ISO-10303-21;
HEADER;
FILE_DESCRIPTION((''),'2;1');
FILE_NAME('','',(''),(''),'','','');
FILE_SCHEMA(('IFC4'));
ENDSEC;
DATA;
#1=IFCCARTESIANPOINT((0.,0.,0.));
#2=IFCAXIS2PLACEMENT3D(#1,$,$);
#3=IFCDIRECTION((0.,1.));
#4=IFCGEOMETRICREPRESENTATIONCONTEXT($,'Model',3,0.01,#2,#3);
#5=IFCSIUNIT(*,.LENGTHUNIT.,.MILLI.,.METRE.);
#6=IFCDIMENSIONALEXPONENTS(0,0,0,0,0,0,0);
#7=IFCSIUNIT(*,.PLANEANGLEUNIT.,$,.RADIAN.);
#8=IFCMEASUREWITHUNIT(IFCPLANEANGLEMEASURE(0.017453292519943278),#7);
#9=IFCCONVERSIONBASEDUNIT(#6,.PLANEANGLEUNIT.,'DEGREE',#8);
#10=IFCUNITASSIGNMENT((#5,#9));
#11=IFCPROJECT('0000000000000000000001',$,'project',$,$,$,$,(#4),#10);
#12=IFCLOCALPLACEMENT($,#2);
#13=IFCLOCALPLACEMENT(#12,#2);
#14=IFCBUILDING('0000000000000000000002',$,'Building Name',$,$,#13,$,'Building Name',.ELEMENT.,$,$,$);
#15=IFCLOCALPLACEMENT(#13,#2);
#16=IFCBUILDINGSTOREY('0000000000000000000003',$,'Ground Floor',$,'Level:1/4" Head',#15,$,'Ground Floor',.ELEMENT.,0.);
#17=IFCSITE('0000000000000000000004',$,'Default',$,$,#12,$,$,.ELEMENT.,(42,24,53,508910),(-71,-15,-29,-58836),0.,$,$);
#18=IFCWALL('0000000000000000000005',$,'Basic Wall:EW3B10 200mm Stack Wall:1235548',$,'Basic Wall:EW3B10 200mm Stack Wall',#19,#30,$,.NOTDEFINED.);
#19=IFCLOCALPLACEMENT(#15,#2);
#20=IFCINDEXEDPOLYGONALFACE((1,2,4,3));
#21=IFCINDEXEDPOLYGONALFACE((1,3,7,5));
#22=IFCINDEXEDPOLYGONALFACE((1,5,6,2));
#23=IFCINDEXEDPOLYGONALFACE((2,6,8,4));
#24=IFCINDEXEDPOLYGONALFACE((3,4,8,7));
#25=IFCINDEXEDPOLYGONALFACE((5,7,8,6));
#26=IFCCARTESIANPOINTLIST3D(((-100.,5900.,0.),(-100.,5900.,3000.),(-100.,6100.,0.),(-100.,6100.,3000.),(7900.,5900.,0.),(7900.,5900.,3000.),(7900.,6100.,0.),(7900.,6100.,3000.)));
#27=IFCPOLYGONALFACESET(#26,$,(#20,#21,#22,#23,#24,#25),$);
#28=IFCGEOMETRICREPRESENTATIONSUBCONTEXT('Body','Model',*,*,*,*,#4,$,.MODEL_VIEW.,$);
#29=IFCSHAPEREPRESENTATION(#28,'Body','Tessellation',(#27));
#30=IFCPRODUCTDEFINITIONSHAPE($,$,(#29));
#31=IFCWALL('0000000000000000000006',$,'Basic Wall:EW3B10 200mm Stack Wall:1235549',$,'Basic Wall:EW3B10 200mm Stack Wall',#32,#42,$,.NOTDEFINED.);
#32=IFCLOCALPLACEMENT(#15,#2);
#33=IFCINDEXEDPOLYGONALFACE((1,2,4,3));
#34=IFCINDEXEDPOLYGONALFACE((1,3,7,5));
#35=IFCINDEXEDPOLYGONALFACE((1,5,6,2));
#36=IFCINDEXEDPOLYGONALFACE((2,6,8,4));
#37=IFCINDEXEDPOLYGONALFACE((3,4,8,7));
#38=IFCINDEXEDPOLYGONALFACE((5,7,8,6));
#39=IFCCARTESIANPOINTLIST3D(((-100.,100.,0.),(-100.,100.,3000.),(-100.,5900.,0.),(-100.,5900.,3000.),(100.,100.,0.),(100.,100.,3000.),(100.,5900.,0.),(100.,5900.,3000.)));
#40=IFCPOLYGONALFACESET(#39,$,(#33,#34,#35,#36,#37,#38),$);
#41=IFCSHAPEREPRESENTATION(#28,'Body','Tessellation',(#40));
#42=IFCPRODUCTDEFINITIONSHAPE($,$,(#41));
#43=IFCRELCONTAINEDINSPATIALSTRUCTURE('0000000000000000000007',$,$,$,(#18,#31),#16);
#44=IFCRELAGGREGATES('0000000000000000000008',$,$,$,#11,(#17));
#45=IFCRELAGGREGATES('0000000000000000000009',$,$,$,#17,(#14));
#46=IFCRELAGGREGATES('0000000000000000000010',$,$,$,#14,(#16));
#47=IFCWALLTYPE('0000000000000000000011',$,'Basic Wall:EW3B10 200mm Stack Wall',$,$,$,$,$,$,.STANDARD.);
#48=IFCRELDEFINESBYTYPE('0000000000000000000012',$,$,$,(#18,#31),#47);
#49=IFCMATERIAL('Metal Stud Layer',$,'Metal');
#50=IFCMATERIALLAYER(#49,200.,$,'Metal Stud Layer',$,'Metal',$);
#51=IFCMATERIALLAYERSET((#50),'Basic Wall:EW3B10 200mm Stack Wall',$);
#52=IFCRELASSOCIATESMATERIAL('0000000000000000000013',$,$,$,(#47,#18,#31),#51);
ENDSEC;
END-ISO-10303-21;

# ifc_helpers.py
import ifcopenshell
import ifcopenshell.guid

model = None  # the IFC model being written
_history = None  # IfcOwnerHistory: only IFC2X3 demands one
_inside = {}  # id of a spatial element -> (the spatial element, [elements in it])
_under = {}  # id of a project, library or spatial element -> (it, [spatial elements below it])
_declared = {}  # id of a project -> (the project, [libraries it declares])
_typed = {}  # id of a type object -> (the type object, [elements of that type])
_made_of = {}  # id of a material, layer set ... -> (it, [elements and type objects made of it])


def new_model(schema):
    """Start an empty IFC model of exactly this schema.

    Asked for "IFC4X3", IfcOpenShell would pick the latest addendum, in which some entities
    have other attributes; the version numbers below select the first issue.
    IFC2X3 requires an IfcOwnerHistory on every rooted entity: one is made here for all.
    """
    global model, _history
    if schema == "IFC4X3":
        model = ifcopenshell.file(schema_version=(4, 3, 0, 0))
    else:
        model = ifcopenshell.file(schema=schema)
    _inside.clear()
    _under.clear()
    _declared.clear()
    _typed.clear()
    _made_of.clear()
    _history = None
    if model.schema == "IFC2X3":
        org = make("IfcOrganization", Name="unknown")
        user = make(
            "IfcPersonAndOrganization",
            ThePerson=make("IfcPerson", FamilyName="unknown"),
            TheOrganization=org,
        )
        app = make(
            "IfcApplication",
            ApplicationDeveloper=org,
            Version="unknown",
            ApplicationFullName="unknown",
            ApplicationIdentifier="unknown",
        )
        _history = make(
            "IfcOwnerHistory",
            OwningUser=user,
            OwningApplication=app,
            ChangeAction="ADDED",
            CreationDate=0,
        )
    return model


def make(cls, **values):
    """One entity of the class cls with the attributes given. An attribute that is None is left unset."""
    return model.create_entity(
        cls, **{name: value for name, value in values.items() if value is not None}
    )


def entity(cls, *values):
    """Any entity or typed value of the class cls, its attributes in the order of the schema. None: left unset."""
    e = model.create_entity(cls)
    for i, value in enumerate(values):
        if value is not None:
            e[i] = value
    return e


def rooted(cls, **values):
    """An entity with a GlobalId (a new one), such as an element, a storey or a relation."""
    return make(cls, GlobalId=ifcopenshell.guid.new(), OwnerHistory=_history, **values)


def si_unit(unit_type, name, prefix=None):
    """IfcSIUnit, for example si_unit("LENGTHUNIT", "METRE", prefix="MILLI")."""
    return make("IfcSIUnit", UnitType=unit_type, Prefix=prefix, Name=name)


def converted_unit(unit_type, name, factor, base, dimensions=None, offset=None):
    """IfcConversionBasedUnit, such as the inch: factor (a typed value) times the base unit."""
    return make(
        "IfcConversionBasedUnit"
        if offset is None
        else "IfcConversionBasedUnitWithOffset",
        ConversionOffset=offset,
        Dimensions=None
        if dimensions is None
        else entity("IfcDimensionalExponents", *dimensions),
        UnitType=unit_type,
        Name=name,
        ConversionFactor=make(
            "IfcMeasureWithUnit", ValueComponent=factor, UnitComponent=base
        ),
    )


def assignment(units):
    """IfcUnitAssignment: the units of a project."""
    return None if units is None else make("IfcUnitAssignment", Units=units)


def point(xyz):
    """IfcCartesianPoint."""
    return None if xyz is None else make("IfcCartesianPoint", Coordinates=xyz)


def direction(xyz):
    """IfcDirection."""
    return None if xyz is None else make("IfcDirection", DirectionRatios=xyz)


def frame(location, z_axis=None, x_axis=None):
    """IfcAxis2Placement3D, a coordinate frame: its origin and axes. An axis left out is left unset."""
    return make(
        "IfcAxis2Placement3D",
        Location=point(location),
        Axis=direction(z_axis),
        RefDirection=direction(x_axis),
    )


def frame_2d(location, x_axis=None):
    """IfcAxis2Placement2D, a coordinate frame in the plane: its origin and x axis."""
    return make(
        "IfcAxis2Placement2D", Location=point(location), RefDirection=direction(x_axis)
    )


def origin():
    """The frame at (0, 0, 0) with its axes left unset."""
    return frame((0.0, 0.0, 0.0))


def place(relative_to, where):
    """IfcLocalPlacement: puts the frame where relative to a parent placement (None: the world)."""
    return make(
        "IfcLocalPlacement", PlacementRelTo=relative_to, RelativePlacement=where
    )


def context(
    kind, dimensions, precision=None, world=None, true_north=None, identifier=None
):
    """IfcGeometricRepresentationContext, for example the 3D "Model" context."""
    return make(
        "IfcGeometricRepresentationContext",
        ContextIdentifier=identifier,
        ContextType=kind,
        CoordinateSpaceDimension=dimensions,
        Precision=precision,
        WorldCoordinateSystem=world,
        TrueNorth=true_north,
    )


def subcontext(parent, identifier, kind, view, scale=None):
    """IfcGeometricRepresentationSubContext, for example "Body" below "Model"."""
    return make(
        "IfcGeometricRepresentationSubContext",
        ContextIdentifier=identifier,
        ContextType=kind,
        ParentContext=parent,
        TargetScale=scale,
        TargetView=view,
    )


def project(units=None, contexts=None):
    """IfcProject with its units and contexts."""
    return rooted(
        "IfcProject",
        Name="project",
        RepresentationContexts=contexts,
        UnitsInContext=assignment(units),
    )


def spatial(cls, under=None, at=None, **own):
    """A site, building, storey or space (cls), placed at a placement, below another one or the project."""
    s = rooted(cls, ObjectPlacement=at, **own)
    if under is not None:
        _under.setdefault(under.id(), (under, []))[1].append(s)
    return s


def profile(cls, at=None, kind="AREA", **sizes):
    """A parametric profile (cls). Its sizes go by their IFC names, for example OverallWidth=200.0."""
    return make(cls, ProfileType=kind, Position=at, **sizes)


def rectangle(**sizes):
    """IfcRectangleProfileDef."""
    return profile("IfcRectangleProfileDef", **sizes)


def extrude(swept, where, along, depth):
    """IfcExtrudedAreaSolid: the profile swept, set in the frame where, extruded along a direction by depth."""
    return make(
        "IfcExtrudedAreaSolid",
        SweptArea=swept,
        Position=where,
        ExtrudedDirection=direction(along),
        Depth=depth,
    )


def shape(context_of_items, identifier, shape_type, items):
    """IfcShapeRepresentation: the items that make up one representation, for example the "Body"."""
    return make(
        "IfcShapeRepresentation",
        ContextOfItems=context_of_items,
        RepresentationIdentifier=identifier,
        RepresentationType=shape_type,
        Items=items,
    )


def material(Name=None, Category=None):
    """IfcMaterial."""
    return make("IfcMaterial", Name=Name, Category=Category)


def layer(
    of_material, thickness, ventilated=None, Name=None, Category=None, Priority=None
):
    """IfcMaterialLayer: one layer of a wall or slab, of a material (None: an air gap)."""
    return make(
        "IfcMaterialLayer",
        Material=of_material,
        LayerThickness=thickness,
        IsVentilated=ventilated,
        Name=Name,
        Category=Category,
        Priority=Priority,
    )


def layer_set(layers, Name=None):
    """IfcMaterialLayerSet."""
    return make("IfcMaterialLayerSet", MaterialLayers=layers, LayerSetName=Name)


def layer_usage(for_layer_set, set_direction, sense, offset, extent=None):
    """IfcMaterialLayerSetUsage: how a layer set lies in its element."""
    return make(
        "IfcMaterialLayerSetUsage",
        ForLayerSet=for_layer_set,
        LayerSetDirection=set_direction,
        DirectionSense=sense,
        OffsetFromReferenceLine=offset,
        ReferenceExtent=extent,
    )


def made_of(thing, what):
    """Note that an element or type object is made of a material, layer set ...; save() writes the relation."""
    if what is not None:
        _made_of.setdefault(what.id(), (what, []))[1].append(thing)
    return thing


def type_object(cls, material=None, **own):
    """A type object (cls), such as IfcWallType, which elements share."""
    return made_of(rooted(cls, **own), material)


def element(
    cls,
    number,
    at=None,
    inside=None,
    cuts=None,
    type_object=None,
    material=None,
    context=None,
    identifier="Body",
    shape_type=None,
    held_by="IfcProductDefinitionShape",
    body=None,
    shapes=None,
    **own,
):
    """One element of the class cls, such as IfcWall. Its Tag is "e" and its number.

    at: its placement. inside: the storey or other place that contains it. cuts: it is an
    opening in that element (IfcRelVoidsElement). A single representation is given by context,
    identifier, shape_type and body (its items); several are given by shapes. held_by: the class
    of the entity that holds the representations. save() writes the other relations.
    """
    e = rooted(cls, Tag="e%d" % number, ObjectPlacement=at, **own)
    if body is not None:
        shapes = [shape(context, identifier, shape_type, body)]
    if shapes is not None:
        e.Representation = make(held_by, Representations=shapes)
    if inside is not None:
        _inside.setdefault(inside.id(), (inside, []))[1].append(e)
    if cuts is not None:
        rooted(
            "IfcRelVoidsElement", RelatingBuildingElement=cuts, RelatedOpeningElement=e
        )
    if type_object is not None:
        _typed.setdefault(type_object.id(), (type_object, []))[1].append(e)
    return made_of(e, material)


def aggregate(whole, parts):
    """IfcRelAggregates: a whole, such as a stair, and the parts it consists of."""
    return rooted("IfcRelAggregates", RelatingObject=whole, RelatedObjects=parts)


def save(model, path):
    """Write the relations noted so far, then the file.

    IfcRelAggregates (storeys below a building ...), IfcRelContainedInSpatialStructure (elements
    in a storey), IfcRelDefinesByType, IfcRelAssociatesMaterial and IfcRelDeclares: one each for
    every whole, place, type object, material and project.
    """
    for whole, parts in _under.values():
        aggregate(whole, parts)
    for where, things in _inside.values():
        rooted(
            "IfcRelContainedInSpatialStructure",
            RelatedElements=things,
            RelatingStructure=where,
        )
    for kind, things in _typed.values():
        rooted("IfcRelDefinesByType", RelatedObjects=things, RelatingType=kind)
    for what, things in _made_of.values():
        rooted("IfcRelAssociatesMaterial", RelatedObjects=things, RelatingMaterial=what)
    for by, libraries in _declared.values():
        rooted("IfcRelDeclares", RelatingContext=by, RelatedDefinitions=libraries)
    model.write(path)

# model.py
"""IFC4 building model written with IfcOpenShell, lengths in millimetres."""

from ifc_helpers import new_model, entity, si_unit, converted_unit, direction, frame, frame_2d, origin, place, context, subcontext, project, spatial, rectangle, extrude, material, layer, layer_set, layer_usage, type_object, element, save


model = new_model("IFC4")

# Units and contexts
model_context = context("Model", 3, precision=0.01, world=origin(), true_north=direction((0.0, 1.0)))
body_context = subcontext(model_context, "Body", "Model", "MODEL_VIEW")
ifc_project = project(units=[si_unit("LENGTHUNIT", "METRE", prefix="MILLI"), converted_unit("PLANEANGLEUNIT", "DEGREE", entity("IfcPlaneAngleMeasure", 0.017453292519943278), si_unit("PLANEANGLEUNIT", "RADIAN"), dimensions=[0, 0, 0, 0, 0, 0, 0])], contexts=[model_context])

# Site, building, storey
site_placement = place(None, origin())
site = spatial("IfcSite", under=ifc_project, at=site_placement, Name="Default", CompositionType="ELEMENT", RefLatitude=(42, 24, 53, 508910), RefLongitude=(-71, -15, -29, -58836), RefElevation=0.0)
building_placement = place(site_placement, origin())
building = spatial("IfcBuilding", under=site, at=building_placement, Name="Building Name", LongName="Building Name", CompositionType="ELEMENT")
storey_placement = place(building_placement, origin())
storey = spatial("IfcBuildingStorey", under=building, at=storey_placement, Name="Ground Floor", ObjectType="Level:1/4\" Head", LongName="Ground Floor", CompositionType="ELEMENT", Elevation=0.0)

# Shared definitions
ifc_material_1 = material(Name="Metal Stud Layer", Category="Metal")
ifc_layer_1 = layer(ifc_material_1, 200.0, Name="Metal Stud Layer", Category="Metal")
ifc_layer_set_1 = layer_set([ifc_layer_1], Name="Basic Wall:EW3B10 200mm Stack Wall")
wall_type = type_object("IfcWallType", Name="Basic Wall:EW3B10 200mm Stack Wall", PredefinedType="STANDARD", material=ifc_layer_set_1)

# Walls
ifc_layer_usage_1 = layer_usage(ifc_layer_set_1, "AXIS2", "NEGATIVE", 100.0)
wall_1_placement = place(storey_placement, frame((7900.0, 6000.0, 0.0), z_axis=(0.0, 0.0, 1.0), x_axis=(-1.0, 0.0, 0.0)))
element("IfcWall", 1, at=wall_1_placement, inside=storey, type_object=wall_type, material=ifc_layer_usage_1, Name="Basic Wall:EW3B10 200mm Stack Wall:1235548", ObjectType="Basic Wall:EW3B10 200mm Stack Wall", PredefinedType="NOTDEFINED", context=body_context, shape_type="SweptSolid", body=[
    extrude(rectangle(XDim=8000.0, YDim=200.0, at=frame_2d((4000.0, 0.0), x_axis=(-1.0, 0.0))), origin(), (0.0, 0.0, 1.0), 3000.0),
])
ifc_layer_usage_2 = layer_usage(ifc_layer_set_1, "AXIS2", "NEGATIVE", 100.0)
wall_2_placement = place(storey_placement, frame((0.0, 5900.0, 0.0), z_axis=(0.0, 0.0, 1.0), x_axis=(0.0, -1.0, 0.0)))
element("IfcWall", 2, at=wall_2_placement, inside=storey, type_object=wall_type, material=ifc_layer_usage_2, Name="Basic Wall:EW3B10 200mm Stack Wall:1235549", ObjectType="Basic Wall:EW3B10 200mm Stack Wall", PredefinedType="NOTDEFINED", context=body_context, shape_type="SweptSolid", body=[
    extrude(rectangle(XDim=5800.0, YDim=200.0, at=frame_2d((2900.0, 0.0), x_axis=(-1.0, 0.0))), origin(), (0.0, 0.0, 1.0), 3000.0),
])

save(model, "model.ifc")
